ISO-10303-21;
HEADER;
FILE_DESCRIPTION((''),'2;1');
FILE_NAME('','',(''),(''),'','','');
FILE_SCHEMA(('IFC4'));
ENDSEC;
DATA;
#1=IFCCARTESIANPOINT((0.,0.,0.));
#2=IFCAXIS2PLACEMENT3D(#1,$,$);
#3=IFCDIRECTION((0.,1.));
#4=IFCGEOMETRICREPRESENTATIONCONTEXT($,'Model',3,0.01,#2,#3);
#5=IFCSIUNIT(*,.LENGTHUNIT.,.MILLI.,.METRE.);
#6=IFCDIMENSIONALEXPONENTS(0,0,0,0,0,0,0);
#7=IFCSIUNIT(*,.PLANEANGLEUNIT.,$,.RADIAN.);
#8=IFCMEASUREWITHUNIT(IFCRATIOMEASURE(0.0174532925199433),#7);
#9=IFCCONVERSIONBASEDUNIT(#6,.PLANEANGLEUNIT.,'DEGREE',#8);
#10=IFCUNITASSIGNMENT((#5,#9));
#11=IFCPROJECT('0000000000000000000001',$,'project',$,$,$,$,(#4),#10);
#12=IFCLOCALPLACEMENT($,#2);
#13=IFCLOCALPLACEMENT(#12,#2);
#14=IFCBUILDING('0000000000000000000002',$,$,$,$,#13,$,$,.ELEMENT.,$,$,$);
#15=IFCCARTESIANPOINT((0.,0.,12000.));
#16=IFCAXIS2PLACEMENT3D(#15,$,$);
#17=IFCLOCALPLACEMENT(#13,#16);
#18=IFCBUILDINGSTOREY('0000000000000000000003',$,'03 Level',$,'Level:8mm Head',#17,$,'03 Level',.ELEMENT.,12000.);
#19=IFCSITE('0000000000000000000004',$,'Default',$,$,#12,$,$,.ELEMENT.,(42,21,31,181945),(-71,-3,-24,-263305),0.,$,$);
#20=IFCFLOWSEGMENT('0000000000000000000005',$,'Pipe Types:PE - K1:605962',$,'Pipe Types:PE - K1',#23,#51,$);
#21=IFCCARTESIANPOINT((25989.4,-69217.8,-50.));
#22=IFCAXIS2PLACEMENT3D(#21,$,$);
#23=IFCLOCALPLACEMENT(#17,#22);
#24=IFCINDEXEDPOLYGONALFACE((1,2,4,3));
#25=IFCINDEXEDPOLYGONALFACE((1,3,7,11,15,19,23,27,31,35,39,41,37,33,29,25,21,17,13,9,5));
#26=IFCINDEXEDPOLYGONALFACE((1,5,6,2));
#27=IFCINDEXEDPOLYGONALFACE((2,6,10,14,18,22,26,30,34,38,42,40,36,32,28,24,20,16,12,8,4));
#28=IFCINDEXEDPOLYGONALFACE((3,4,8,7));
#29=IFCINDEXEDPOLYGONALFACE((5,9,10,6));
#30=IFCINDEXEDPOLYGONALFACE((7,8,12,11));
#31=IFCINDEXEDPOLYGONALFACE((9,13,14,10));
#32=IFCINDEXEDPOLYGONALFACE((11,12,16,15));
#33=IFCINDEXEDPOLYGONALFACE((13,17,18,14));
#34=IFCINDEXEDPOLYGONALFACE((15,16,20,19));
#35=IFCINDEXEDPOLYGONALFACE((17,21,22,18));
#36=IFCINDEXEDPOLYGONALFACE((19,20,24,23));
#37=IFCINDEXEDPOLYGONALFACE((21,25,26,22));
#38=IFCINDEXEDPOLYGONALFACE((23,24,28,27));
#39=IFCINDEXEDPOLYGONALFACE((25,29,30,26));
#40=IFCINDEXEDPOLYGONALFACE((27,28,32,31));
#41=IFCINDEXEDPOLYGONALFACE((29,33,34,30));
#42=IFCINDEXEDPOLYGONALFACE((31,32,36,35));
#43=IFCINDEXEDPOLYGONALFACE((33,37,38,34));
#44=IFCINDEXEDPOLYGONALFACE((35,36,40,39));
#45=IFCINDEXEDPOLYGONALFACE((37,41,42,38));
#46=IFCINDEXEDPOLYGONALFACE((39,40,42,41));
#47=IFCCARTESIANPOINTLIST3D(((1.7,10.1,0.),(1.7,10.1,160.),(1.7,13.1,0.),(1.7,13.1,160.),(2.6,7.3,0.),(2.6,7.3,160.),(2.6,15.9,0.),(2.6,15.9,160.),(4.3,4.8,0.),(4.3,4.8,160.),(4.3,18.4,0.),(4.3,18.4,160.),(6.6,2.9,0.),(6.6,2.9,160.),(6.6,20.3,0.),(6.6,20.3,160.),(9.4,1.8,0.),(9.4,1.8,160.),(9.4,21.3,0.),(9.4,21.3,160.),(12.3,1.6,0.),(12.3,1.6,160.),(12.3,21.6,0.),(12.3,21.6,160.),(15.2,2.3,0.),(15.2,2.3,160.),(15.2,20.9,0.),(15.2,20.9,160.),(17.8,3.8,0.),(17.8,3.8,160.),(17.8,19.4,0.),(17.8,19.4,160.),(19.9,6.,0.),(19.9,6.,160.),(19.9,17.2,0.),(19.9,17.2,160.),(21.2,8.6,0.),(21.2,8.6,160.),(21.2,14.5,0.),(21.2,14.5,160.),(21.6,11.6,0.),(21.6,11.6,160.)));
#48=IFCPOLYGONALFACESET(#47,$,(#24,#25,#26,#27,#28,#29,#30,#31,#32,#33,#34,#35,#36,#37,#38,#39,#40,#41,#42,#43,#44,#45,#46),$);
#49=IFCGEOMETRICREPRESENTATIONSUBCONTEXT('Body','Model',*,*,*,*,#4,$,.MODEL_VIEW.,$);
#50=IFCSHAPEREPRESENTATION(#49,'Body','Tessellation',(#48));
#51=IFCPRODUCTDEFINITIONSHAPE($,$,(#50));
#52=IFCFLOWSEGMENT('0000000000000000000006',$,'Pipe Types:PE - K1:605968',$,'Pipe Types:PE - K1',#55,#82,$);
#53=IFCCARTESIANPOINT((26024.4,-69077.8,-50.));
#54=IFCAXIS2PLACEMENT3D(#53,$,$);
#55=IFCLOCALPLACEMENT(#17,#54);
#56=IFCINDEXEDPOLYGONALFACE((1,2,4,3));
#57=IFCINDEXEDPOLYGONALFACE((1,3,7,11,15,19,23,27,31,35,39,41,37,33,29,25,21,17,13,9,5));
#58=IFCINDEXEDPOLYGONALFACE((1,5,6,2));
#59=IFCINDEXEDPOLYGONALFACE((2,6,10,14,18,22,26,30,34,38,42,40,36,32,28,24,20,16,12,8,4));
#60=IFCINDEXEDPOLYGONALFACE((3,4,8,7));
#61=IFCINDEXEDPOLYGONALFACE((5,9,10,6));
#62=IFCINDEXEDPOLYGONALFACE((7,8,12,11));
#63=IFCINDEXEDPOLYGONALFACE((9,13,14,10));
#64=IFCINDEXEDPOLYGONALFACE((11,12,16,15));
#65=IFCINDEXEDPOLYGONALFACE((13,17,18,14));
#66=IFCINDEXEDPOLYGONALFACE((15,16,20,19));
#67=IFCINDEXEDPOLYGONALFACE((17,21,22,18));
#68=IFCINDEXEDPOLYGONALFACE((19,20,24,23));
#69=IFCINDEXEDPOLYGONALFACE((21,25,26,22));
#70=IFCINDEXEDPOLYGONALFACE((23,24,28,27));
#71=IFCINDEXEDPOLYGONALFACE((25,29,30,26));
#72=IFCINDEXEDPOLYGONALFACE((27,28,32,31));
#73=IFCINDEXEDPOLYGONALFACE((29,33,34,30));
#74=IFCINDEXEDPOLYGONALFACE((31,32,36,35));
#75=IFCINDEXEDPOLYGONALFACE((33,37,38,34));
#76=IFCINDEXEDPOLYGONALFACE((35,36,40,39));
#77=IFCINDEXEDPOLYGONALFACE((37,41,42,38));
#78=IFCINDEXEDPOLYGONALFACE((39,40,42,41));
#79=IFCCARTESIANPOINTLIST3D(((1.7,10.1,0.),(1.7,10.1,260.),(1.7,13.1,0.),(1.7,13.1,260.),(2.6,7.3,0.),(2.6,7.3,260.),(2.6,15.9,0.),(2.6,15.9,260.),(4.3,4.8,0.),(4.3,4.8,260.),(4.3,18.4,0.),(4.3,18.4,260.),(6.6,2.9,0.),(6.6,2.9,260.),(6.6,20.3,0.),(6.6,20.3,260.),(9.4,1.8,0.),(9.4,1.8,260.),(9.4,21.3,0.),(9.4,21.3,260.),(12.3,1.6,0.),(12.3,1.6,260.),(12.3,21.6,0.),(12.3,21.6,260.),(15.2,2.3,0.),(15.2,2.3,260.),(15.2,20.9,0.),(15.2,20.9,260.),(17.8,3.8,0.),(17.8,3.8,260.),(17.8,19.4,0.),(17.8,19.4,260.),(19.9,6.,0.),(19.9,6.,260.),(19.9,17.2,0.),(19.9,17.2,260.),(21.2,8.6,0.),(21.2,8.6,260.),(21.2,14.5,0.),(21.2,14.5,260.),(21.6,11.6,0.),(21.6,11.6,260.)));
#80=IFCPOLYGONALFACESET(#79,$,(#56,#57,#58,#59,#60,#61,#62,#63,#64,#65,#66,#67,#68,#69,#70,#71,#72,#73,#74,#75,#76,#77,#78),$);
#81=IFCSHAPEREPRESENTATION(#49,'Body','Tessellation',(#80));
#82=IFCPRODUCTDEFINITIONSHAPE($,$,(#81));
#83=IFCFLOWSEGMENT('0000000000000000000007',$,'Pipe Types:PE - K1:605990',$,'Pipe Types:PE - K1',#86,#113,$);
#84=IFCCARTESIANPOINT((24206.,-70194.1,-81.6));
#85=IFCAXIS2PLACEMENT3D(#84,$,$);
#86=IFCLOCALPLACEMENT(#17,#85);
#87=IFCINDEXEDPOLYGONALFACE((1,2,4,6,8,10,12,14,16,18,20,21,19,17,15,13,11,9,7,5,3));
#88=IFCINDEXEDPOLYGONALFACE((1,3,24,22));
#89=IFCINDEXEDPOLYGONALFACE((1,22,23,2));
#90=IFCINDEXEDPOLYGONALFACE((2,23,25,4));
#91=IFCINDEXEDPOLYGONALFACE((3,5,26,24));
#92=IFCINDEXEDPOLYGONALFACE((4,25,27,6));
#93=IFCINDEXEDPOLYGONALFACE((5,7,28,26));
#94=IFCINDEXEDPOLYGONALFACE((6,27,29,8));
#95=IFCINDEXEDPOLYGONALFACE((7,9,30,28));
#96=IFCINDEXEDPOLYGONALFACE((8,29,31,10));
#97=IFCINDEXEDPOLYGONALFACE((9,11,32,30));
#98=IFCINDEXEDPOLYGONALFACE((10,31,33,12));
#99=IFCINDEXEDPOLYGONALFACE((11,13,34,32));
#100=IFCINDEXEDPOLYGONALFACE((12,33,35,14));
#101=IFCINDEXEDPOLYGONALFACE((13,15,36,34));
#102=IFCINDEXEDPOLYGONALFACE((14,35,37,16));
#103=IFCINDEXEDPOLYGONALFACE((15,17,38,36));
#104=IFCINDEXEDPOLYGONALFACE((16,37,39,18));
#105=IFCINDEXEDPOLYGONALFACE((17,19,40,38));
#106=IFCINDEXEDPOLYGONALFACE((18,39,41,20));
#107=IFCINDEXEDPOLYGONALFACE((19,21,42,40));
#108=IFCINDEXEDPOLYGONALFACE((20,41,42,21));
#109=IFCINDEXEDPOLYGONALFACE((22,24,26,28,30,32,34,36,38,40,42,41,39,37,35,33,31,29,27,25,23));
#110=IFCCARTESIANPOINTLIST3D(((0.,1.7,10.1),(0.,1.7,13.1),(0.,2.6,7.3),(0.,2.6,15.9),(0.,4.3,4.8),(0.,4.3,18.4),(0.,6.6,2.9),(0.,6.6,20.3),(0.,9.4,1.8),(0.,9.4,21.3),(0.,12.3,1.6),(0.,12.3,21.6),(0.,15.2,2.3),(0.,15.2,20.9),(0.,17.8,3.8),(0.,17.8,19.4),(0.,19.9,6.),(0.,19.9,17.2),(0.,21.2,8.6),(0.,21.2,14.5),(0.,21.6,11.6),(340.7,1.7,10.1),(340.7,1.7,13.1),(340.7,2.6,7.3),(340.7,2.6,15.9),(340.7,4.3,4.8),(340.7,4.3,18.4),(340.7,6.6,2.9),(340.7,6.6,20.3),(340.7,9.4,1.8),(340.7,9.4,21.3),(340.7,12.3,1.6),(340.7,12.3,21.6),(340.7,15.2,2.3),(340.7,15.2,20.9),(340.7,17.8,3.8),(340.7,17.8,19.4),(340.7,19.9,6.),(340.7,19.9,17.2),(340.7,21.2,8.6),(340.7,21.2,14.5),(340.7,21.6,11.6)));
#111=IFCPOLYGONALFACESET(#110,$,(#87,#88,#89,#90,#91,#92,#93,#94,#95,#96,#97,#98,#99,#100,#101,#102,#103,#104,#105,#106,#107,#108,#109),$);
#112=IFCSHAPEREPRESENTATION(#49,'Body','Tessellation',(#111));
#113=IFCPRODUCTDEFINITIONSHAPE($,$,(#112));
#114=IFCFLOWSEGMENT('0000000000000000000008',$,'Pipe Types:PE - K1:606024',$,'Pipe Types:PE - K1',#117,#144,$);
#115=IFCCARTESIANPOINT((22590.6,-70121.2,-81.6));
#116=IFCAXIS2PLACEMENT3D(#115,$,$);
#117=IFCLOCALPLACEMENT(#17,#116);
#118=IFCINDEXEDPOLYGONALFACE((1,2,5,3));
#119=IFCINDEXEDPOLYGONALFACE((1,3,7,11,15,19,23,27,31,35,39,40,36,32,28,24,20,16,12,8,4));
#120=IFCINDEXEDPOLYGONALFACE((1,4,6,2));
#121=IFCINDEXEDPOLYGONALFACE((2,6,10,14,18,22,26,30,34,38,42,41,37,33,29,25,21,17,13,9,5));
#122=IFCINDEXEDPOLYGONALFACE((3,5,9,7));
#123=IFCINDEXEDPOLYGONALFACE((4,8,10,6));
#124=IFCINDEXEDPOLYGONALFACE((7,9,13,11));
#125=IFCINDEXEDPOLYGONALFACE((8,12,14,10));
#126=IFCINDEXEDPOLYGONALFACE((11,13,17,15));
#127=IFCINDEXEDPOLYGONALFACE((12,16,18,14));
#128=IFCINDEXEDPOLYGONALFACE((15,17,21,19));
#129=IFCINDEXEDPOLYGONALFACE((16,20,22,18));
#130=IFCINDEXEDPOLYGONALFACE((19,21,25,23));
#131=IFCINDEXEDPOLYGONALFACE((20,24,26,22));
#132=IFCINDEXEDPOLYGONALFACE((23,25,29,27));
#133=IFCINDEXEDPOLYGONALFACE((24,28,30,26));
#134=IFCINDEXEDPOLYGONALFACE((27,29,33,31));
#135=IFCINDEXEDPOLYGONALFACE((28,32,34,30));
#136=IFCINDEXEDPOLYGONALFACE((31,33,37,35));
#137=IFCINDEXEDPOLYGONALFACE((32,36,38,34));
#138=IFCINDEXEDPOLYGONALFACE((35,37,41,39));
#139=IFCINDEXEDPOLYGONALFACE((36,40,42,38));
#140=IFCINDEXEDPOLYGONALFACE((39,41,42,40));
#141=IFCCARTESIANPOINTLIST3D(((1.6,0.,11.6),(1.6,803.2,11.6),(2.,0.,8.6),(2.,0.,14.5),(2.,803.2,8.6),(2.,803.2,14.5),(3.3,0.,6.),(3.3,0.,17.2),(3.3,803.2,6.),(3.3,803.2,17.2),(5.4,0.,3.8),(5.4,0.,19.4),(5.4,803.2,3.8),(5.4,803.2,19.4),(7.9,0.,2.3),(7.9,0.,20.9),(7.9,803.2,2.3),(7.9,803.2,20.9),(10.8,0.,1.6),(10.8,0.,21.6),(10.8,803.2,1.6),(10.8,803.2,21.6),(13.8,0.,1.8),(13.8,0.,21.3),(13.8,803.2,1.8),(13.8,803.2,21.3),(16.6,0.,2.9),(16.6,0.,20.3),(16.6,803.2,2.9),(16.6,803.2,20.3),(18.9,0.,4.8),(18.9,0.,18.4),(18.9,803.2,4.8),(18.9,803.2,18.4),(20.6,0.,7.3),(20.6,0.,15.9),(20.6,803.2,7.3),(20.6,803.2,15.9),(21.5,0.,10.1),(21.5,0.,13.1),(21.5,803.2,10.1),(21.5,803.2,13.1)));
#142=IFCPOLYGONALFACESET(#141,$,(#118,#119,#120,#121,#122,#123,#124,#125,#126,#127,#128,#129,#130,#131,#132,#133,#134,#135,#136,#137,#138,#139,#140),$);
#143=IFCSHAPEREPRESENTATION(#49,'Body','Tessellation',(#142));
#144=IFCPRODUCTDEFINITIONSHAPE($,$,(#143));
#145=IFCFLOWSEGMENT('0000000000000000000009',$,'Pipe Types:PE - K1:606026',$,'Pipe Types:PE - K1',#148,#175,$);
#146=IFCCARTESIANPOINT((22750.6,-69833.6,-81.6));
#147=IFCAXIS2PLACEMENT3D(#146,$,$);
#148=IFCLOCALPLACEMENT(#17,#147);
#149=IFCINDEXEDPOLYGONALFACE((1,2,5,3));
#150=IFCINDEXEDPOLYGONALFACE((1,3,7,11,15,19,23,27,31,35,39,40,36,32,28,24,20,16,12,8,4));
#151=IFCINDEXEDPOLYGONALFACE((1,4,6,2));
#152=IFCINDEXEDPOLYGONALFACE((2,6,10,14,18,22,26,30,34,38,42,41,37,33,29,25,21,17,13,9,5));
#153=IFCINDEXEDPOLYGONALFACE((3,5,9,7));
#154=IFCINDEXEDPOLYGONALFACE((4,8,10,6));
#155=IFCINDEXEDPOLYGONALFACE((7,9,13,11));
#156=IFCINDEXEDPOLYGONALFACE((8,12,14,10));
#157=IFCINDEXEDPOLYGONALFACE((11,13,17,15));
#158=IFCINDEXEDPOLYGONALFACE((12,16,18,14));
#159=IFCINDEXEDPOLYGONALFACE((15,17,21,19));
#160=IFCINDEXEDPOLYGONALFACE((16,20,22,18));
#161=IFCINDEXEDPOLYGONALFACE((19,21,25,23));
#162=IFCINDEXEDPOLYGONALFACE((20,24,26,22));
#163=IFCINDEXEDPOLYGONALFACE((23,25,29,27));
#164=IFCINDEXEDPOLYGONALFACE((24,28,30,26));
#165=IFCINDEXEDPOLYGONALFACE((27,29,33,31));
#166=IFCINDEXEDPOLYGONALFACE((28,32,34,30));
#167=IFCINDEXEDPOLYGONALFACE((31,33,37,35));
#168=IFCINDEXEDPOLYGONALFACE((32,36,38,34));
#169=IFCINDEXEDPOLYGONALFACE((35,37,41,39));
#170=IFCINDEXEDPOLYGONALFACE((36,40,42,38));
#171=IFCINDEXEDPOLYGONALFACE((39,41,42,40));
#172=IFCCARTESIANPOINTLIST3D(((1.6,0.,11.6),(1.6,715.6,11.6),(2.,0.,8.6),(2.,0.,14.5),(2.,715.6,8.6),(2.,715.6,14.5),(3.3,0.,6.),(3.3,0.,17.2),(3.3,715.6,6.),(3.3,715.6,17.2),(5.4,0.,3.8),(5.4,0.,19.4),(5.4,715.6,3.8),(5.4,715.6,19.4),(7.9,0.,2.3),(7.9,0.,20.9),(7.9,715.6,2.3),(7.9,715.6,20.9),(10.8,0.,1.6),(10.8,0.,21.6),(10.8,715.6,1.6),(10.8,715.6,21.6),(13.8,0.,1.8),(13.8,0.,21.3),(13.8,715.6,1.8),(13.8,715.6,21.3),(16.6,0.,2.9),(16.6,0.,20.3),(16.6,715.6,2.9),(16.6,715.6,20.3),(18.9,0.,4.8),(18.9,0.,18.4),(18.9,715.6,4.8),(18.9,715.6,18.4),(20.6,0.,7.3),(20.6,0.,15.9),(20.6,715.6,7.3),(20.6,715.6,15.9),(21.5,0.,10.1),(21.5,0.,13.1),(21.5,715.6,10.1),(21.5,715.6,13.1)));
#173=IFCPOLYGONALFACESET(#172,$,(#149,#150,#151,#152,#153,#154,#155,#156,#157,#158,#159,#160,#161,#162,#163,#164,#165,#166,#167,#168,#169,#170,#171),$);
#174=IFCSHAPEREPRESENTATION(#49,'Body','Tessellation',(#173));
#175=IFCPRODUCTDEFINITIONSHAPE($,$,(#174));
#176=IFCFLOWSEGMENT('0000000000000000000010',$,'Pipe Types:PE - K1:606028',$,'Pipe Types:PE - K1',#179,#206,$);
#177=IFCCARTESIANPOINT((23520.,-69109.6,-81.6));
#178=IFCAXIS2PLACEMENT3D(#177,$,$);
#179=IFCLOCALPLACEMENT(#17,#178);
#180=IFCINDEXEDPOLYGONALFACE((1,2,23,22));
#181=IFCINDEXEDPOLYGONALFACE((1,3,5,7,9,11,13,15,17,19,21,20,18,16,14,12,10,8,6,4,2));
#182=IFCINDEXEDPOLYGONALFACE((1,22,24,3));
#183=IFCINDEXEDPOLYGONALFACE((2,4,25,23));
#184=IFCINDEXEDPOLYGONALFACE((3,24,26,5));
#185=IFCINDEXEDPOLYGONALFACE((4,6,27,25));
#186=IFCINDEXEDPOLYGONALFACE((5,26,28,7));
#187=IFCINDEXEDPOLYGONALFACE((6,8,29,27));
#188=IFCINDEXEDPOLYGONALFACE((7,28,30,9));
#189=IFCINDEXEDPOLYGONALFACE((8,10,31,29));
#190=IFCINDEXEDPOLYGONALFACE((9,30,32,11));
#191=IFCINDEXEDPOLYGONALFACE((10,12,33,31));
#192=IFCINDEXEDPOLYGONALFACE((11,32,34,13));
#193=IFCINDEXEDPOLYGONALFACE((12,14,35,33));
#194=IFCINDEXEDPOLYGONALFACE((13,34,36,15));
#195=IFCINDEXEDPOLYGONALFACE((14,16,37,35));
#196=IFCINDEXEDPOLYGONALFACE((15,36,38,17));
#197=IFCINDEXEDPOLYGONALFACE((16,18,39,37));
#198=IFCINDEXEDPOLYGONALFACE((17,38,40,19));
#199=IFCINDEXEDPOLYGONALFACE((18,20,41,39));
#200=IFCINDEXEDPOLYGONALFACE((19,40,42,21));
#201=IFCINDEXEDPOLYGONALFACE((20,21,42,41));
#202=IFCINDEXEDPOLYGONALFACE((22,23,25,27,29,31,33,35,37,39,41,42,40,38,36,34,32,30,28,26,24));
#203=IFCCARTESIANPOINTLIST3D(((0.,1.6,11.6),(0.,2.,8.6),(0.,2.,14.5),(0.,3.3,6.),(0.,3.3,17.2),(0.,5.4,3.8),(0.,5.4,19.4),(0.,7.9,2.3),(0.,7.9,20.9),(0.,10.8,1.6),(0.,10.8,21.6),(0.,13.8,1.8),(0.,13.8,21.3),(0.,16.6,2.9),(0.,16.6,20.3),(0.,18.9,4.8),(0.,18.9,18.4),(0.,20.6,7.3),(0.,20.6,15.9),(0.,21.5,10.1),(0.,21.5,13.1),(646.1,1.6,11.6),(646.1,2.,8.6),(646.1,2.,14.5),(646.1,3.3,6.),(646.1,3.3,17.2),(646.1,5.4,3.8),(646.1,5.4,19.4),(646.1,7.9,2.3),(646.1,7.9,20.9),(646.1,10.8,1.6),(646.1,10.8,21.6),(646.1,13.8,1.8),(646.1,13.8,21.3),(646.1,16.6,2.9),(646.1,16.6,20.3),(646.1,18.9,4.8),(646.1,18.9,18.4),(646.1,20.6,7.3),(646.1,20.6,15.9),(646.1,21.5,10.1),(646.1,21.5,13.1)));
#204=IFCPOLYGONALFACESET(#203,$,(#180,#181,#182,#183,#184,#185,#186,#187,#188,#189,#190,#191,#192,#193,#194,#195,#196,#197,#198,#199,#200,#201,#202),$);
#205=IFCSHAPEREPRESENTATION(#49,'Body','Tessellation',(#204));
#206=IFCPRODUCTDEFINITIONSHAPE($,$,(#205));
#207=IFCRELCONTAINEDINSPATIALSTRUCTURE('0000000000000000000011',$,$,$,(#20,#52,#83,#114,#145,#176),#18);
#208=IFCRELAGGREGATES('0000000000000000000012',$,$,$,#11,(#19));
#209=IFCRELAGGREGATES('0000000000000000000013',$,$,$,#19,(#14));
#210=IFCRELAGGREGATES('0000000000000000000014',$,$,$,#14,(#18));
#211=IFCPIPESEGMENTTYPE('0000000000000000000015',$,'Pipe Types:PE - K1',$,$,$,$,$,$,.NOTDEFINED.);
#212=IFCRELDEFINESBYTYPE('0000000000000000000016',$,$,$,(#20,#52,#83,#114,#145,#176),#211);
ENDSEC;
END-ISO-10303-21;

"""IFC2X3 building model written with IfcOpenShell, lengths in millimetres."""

from ifc_helpers import new_model, entity, si_unit, converted_unit, direction, frame, frame_2d, origin, origin_2d_with_axis, place, context, subcontext, project, spatial, circle, extrude, type_object, element, save


model = new_model("IFC2X3")

# Units and contexts
model_context = context("Model", 3, precision=0.01, world=origin(), true_north=direction((0.0, 1.0)))
body_context = subcontext(model_context, "Body", "Model", "MODEL_VIEW")
ifc_project = project(units=[si_unit("LENGTHUNIT", "METRE", prefix="MILLI"), converted_unit("PLANEANGLEUNIT", "DEGREE", entity("IfcRatioMeasure", 0.0174532925199433), si_unit("PLANEANGLEUNIT", "RADIAN"), dimensions=[0, 0, 0, 0, 0, 0, 0])], contexts=[model_context])

# Site, building, storey
site_placement = place(None, origin())
site = spatial("IfcSite", under=ifc_project, at=site_placement, Name="Default", CompositionType="ELEMENT", RefLatitude=(42, 21, 31, 181945), RefLongitude=(-71, -3, -24, -263305), RefElevation=0.0)
building_placement = place(site_placement, origin())
building = spatial("IfcBuilding", under=site, at=building_placement, CompositionType="ELEMENT")
storey_placement = place(building_placement, frame((0.0, 0.0, 12000.0)))
storey = spatial("IfcBuildingStorey", under=building, at=storey_placement, Name="03 Level", ObjectType="Level:8mm Head", LongName="03 Level", CompositionType="ELEMENT", Elevation=12000.0)

# Flow segments
pipe_segment_type = type_object("IfcPipeSegmentType", Name="Pipe Types:PE - K1", PredefinedType="NOTDEFINED")
flow_segment_1_placement = place(storey_placement, frame((25989.4, -69217.8, -50.0)))
element("IfcFlowSegment", 1, at=flow_segment_1_placement, inside=storey, type_object=pipe_segment_type, Name="Pipe Types:PE - K1:605962", ObjectType="Pipe Types:PE - K1", context=body_context, shape_type="SweptSolid", body=[
    extrude(circle(Radius=10.0, at=origin_2d_with_axis()), frame((11.6, 11.6, 0.0)), (0.0, 0.0, 1.0), 160.0),
])
flow_segment_2_placement = place(storey_placement, frame((26024.4, -69077.8, -50.0)))
element("IfcFlowSegment", 2, at=flow_segment_2_placement, inside=storey, type_object=pipe_segment_type, Name="Pipe Types:PE - K1:605968", ObjectType="Pipe Types:PE - K1", context=body_context, shape_type="SweptSolid", body=[
    extrude(circle(Radius=10.0, at=origin_2d_with_axis()), frame((11.6, 11.6, 0.0)), (0.0, 0.0, 1.0), 260.0),
])
flow_segment_3_placement = place(storey_placement, frame((24206.0, -70194.1, -81.6)))
element("IfcFlowSegment", 3, at=flow_segment_3_placement, inside=storey, type_object=pipe_segment_type, Name="Pipe Types:PE - K1:605990", ObjectType="Pipe Types:PE - K1", context=body_context, shape_type="SweptSolid", body=[
    extrude(circle(Radius=10.0, at=frame_2d((0.0, 0.0), x_axis=(1.0, 0.0))), frame((0.0, 11.6, 11.6), z_axis=(1.0, 0.0, 0.0), x_axis=(0.0, 1.0, 0.0)), (0.0, 0.0, 1.0), 340.7),
])
flow_segment_4_placement = place(storey_placement, frame((22590.6, -70121.2, -81.6)))
element("IfcFlowSegment", 4, at=flow_segment_4_placement, inside=storey, type_object=pipe_segment_type, Name="Pipe Types:PE - K1:606024", ObjectType="Pipe Types:PE - K1", context=body_context, shape_type="SweptSolid", body=[
    extrude(circle(Radius=10.0, at=frame_2d((0.0, 0.0), x_axis=(1.0, 0.0))), frame((11.6, 0.0, 11.6), z_axis=(0.0, 1.0, 0.0), x_axis=(-1.0, 0.0, 0.0)), (0.0, 0.0, 1.0), 803.2),
])
flow_segment_5_placement = place(storey_placement, frame((22750.6, -69833.6, -81.6)))
element("IfcFlowSegment", 5, at=flow_segment_5_placement, inside=storey, type_object=pipe_segment_type, Name="Pipe Types:PE - K1:606026", ObjectType="Pipe Types:PE - K1", context=body_context, shape_type="SweptSolid", body=[
    extrude(circle(Radius=10.0, at=frame_2d((0.0, 0.0), x_axis=(1.0, 0.0))), frame((11.6, 0.0, 11.6), z_axis=(0.0, 1.0, 0.0), x_axis=(-1.0, 0.0, 0.0)), (0.0, 0.0, 1.0), 715.6),
])
flow_segment_6_placement = place(storey_placement, frame((23520.0, -69109.6, -81.6)))
element("IfcFlowSegment", 6, at=flow_segment_6_placement, inside=storey, type_object=pipe_segment_type, Name="Pipe Types:PE - K1:606028", ObjectType="Pipe Types:PE - K1", context=body_context, shape_type="SweptSolid", body=[
    extrude(circle(Radius=10.0, at=origin_2d_with_axis()), frame((0.0, 11.6, 11.6), z_axis=(1.0, 0.0, 0.0), x_axis=(0.0, -1.0, 0.0)), (0.0, 0.0, 1.0), 646.1),
])

save(model, "model.ifc")
